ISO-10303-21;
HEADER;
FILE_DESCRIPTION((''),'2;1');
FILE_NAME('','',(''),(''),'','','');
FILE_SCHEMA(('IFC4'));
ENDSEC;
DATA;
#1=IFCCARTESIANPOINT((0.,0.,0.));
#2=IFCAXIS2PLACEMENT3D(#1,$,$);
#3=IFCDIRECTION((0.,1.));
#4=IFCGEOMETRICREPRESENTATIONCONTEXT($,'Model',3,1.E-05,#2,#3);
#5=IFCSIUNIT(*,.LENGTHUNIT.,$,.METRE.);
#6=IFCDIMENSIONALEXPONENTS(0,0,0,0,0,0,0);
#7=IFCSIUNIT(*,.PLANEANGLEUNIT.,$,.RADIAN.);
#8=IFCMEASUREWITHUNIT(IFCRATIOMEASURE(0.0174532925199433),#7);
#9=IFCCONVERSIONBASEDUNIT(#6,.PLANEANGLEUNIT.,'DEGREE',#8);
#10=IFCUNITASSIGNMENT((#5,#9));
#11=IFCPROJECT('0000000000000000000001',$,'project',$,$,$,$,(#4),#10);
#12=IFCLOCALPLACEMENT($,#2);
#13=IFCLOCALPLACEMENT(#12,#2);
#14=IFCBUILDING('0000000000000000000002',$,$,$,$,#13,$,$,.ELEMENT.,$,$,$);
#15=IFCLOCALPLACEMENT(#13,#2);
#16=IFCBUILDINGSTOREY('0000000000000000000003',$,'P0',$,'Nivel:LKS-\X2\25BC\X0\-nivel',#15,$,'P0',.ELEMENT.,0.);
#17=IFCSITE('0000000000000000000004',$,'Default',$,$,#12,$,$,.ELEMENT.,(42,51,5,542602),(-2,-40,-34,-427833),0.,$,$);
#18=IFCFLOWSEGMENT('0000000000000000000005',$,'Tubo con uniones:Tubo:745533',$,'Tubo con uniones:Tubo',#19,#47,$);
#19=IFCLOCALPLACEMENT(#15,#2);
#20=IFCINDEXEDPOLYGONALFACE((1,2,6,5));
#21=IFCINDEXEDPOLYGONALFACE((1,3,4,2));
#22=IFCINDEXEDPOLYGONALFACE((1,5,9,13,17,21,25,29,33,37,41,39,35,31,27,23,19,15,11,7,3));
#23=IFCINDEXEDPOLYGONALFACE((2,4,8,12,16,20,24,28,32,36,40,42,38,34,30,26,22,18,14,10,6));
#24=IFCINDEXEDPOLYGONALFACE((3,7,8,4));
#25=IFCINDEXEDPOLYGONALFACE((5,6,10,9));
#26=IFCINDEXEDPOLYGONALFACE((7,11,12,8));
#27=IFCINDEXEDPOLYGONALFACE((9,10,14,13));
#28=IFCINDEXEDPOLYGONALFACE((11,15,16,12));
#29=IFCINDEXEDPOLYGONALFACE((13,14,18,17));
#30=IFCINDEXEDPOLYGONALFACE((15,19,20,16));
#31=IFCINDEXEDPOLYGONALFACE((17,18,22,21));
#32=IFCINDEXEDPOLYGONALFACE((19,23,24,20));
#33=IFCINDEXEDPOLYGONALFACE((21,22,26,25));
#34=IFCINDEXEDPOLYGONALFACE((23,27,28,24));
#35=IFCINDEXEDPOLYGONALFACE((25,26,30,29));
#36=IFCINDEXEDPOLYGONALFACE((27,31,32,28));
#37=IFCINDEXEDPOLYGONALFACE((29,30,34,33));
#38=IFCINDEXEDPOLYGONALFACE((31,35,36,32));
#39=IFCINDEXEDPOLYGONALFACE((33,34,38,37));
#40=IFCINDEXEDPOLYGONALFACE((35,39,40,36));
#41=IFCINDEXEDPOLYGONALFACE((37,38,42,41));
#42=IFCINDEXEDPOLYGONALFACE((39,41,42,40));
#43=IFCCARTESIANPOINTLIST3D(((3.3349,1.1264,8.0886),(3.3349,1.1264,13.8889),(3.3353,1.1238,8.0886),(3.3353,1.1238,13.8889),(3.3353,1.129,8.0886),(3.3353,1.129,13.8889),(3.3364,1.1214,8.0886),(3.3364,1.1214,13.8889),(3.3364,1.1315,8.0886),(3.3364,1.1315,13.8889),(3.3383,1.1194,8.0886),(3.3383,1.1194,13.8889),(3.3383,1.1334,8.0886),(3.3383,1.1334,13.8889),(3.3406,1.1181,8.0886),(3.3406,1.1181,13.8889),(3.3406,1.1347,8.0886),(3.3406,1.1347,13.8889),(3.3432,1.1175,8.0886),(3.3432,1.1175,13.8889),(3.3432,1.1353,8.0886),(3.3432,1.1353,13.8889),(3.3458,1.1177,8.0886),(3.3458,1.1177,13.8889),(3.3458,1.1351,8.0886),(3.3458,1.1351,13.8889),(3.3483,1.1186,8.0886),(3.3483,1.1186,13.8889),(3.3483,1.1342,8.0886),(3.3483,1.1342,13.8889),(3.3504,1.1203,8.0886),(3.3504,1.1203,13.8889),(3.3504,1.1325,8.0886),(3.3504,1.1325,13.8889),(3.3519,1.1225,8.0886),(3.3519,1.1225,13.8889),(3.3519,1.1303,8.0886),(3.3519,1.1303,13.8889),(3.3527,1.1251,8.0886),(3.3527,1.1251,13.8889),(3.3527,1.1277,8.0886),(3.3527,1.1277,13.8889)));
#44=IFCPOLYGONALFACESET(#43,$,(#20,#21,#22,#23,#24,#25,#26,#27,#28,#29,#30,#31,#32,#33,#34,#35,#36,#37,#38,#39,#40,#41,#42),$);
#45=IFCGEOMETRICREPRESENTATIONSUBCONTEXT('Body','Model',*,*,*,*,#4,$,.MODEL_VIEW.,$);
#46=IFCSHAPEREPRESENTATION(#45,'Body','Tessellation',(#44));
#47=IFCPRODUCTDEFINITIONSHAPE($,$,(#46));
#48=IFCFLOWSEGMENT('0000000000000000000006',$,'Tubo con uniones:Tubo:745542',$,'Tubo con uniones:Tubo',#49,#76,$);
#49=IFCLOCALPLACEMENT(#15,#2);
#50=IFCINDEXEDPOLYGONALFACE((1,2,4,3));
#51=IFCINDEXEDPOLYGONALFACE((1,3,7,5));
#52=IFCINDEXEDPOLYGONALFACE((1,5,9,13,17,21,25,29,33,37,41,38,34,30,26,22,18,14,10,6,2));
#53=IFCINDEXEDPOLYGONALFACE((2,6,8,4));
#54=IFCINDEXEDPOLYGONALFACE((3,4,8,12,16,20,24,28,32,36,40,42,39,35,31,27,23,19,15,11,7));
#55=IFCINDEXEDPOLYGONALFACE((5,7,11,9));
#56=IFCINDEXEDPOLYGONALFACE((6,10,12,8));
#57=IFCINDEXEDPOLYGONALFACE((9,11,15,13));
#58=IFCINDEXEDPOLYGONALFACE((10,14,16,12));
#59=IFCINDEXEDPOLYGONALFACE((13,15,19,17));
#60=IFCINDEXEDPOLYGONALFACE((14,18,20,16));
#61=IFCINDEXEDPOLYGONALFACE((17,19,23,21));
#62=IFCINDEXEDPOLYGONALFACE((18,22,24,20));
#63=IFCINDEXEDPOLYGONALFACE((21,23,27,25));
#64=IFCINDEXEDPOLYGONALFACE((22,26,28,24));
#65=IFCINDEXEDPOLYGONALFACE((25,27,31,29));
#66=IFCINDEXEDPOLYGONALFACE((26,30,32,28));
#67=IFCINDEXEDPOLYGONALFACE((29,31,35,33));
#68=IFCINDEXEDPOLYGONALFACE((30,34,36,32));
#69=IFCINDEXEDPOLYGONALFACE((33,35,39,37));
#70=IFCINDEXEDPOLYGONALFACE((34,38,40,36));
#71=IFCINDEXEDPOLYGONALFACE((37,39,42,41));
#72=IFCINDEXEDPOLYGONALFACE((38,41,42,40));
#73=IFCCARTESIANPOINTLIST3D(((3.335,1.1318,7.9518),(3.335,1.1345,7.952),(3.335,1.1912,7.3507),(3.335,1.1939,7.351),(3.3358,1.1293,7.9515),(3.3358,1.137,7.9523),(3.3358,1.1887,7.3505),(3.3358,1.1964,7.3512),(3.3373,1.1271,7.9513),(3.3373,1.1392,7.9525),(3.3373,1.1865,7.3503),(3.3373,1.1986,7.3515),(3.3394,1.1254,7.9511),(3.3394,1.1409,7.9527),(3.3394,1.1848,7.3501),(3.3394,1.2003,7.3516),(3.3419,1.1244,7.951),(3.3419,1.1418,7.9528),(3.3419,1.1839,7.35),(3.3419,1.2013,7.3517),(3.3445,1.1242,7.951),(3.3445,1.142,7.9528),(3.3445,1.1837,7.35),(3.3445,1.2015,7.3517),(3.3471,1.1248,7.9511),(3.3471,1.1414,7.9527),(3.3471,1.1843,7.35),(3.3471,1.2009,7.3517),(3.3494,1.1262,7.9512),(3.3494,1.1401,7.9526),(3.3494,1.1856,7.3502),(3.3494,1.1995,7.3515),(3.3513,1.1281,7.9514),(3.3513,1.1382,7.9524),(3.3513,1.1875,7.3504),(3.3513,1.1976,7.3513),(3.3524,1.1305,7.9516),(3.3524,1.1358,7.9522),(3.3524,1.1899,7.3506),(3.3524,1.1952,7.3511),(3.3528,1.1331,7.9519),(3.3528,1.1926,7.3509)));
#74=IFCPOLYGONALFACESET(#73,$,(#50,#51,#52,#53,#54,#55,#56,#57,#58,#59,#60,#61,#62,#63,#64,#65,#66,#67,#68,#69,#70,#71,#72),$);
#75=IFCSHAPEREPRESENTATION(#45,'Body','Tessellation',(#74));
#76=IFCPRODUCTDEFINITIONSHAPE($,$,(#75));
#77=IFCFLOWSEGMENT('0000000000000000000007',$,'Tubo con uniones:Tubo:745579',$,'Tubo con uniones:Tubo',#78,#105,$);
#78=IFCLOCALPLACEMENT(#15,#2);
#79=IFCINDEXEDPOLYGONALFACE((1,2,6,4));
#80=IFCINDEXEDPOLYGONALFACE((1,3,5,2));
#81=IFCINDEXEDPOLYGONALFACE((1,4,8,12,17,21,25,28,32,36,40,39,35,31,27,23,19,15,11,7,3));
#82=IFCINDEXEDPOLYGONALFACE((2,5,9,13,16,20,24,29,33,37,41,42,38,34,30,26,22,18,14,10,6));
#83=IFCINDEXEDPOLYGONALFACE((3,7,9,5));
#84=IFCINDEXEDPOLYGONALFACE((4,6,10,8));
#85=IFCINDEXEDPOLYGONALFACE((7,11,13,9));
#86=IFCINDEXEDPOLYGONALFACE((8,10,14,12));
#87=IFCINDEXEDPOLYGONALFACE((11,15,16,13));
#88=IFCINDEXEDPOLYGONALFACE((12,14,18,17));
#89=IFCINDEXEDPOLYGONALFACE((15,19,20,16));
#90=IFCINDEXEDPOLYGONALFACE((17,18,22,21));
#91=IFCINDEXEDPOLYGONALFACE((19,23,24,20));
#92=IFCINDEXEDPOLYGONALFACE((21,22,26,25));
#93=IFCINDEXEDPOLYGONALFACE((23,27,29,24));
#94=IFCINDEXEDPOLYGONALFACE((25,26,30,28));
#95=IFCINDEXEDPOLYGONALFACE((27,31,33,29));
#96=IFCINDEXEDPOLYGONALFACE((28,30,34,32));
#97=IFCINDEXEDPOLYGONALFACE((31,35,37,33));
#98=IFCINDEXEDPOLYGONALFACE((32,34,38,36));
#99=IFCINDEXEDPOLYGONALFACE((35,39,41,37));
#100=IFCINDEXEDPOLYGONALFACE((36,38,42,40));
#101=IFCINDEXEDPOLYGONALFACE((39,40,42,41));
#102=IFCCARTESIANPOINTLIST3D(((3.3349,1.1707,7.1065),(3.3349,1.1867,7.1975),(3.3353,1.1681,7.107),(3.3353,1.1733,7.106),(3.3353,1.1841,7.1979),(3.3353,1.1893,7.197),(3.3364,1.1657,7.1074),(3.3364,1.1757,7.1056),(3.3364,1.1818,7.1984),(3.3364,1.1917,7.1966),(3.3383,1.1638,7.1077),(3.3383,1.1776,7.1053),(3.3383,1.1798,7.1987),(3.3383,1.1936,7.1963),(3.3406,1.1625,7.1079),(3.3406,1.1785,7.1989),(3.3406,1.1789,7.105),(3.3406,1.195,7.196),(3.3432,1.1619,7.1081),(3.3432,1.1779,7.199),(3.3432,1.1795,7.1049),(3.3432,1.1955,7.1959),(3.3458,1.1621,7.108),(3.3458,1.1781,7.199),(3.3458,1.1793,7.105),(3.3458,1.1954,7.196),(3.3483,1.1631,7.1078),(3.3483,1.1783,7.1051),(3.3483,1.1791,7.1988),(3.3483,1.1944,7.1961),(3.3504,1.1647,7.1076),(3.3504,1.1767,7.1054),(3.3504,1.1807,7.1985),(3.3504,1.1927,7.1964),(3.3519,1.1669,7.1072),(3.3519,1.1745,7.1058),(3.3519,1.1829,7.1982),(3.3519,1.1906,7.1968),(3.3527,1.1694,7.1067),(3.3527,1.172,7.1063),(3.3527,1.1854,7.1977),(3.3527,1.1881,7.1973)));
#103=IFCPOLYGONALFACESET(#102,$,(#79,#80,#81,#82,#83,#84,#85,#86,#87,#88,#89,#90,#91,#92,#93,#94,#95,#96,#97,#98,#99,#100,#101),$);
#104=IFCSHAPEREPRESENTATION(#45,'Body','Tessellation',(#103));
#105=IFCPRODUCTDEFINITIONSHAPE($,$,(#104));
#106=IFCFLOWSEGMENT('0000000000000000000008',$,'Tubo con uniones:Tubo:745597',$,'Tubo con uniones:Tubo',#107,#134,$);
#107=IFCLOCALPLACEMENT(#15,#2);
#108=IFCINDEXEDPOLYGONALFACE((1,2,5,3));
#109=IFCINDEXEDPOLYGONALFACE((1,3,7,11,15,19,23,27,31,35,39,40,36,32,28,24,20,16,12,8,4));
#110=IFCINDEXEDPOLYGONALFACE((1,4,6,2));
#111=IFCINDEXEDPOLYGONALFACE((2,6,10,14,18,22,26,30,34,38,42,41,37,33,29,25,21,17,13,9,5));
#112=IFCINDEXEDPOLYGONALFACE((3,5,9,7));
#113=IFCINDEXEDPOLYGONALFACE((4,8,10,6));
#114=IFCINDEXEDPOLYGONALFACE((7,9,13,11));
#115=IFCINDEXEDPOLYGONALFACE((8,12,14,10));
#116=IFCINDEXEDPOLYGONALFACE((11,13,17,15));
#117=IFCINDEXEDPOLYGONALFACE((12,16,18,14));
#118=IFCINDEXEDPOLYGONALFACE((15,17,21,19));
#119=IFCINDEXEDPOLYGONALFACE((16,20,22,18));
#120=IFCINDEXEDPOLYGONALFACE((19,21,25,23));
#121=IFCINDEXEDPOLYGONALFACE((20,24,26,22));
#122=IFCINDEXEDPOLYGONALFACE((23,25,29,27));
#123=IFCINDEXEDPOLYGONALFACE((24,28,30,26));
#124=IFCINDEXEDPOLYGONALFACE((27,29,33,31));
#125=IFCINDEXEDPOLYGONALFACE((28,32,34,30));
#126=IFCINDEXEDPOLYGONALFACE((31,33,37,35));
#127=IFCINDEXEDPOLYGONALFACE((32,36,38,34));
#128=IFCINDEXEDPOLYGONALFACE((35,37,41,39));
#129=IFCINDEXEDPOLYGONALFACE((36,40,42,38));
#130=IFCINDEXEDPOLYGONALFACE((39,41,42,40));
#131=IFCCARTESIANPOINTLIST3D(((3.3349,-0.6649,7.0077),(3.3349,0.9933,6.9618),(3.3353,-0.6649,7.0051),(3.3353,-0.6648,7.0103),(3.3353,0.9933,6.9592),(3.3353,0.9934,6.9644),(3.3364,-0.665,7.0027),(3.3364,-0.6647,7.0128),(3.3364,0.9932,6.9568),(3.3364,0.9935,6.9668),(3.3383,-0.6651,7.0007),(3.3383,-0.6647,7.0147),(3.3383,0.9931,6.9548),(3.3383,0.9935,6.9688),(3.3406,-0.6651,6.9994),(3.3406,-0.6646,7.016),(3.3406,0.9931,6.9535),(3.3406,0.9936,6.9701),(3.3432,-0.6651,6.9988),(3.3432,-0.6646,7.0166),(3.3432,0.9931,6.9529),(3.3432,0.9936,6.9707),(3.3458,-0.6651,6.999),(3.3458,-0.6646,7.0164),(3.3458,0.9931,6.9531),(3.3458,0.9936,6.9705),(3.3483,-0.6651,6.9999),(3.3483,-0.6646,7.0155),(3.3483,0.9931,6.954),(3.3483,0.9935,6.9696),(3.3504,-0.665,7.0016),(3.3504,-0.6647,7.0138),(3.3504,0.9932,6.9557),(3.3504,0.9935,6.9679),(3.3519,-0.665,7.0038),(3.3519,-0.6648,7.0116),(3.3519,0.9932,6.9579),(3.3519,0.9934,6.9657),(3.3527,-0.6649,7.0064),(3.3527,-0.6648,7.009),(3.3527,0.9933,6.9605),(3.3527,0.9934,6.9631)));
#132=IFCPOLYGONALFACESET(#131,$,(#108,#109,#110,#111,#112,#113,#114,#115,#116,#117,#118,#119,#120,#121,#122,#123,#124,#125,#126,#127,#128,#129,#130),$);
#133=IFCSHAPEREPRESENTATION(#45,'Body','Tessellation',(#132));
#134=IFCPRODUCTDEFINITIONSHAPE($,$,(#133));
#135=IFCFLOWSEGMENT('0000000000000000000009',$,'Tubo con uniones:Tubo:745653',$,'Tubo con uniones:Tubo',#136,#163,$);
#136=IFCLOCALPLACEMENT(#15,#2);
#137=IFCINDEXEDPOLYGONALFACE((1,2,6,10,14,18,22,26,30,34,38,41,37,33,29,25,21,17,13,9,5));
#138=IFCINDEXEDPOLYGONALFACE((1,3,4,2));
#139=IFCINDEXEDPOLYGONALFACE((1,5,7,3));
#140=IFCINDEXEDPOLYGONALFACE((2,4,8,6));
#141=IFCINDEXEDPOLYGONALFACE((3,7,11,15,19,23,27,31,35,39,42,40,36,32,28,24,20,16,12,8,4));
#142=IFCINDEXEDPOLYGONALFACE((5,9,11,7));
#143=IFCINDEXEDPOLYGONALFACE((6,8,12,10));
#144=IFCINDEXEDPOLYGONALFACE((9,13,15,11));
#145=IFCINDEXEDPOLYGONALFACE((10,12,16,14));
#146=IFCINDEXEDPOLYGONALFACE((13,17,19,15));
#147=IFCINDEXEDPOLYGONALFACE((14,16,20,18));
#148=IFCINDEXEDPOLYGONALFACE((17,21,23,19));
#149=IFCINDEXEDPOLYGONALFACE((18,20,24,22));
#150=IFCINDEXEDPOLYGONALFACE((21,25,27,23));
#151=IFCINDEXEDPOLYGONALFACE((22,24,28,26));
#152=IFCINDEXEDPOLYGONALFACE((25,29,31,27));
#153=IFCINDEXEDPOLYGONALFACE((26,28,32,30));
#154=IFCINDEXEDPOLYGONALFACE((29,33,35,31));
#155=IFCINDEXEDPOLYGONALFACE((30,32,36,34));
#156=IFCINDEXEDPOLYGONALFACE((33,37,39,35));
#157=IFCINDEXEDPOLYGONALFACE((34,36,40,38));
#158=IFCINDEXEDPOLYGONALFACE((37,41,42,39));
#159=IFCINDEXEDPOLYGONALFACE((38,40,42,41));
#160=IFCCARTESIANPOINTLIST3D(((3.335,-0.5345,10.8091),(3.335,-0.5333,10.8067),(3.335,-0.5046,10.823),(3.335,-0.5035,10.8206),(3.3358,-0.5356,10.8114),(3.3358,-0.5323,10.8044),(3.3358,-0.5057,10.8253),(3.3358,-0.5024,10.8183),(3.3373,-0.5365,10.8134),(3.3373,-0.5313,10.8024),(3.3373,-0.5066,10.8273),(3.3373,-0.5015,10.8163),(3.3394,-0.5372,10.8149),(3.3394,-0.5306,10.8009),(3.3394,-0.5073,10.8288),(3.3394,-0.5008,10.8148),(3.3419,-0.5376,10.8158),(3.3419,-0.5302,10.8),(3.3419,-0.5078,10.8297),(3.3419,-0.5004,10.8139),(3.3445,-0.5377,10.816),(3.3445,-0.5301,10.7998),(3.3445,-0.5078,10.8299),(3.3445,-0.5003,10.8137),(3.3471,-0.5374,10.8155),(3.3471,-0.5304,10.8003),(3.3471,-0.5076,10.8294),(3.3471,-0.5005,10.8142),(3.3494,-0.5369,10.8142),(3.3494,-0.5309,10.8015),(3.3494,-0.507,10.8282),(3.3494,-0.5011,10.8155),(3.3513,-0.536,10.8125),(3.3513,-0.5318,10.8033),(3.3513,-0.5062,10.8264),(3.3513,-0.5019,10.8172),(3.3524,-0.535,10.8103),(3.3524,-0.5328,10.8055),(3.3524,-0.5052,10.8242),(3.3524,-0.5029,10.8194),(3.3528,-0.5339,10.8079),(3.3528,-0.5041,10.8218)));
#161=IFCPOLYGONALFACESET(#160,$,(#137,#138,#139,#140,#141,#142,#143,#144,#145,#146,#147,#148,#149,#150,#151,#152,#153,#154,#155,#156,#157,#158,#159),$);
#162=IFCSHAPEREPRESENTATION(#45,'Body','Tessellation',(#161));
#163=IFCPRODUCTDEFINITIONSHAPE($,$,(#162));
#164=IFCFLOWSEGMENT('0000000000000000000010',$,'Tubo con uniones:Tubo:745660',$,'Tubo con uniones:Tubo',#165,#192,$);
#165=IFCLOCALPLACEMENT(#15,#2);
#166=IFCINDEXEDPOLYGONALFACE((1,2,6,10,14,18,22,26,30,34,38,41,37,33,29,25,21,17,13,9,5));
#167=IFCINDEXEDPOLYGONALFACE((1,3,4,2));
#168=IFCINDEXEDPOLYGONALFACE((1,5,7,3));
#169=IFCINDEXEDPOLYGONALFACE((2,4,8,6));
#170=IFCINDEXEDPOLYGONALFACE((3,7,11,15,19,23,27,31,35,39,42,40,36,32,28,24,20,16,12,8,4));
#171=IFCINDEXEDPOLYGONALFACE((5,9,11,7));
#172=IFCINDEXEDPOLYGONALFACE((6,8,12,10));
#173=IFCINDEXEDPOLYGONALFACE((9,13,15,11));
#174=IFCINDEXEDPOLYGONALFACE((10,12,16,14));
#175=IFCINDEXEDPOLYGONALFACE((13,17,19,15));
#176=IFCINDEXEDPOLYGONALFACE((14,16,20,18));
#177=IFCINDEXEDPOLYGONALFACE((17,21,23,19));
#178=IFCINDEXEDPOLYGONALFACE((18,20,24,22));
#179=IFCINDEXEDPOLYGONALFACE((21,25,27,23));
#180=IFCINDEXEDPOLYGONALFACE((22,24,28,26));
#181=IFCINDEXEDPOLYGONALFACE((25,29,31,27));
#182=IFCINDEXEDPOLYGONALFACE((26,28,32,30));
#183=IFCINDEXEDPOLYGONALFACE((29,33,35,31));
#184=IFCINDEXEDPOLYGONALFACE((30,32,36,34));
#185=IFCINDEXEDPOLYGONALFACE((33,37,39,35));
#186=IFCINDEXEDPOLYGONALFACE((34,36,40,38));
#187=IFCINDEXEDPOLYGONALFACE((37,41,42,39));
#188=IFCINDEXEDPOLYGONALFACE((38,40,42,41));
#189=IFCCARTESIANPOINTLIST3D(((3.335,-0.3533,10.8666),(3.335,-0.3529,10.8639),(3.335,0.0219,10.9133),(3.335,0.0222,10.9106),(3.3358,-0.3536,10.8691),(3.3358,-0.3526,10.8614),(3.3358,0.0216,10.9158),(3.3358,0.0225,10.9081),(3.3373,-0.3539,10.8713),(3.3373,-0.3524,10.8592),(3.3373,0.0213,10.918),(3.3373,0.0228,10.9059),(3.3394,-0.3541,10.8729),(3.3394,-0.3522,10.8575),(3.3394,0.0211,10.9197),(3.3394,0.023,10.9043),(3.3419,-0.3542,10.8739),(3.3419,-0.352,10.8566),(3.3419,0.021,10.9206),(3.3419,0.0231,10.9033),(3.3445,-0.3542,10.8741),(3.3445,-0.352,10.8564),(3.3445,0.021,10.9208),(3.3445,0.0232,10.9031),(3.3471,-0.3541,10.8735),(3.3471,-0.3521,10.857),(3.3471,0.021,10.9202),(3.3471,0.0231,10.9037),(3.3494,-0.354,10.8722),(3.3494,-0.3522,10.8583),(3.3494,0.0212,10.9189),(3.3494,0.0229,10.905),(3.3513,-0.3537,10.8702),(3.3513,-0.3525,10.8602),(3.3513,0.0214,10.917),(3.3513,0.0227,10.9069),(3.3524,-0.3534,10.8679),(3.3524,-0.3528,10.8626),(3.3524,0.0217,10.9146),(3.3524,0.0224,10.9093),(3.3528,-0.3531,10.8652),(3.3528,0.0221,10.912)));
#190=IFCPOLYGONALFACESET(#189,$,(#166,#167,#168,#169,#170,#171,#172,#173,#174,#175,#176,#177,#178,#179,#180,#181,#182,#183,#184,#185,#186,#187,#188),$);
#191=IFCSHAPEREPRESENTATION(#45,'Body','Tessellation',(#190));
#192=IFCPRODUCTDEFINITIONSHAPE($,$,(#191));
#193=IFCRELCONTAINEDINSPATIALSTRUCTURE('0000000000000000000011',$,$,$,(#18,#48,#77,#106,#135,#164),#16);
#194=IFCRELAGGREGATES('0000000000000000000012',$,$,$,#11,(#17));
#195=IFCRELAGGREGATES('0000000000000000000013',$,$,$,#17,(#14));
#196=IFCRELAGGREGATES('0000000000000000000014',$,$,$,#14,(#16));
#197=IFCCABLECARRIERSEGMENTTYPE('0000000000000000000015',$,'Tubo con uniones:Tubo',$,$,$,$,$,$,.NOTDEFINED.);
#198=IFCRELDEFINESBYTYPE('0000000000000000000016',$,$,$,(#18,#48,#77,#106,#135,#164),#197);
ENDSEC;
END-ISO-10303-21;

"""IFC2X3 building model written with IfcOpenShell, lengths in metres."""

from ifc_helpers import new_model, entity, si_unit, converted_unit, direction, frame, frame_2d, origin, origin_2d_with_axis, place, context, subcontext, project, spatial, circle, extrude, type_object, element, save


model = new_model("IFC2X3")

# Units and contexts
model_context = context("Model", 3, precision=1e-05, world=origin(), true_north=direction((0.0, 1.0)))
body_context = subcontext(model_context, "Body", "Model", "MODEL_VIEW")
ifc_project = project(units=[si_unit("LENGTHUNIT", "METRE"), converted_unit("PLANEANGLEUNIT", "DEGREE", entity("IfcRatioMeasure", 0.0174532925199433), si_unit("PLANEANGLEUNIT", "RADIAN"), dimensions=[0, 0, 0, 0, 0, 0, 0])], contexts=[model_context])

# Site, building, storey
site_placement = place(None, origin())
site = spatial("IfcSite", under=ifc_project, at=site_placement, Name="Default", CompositionType="ELEMENT", RefLatitude=(42, 51, 5, 542602), RefLongitude=(-2, -40, -34, -427833), RefElevation=0.0)
building_placement = place(site_placement, origin())
building = spatial("IfcBuilding", under=site, at=building_placement, CompositionType="ELEMENT")
storey_placement = place(building_placement, origin())
storey = spatial("IfcBuildingStorey", under=building, at=storey_placement, Name="P0", ObjectType="Nivel:LKS-▼-nivel", LongName="P0", CompositionType="ELEMENT", Elevation=0.0)

# Flow segments
cable_carrier_segment_type = type_object("IfcCableCarrierSegmentType", Name="Tubo con uniones:Tubo", PredefinedType="NOTDEFINED")
flow_segment_1_placement = place(storey_placement, origin())
element("IfcFlowSegment", 1, at=flow_segment_1_placement, inside=storey, type_object=cable_carrier_segment_type, Name="Tubo con uniones:Tubo:745533", ObjectType="Tubo con uniones:Tubo", context=body_context, shape_type="SweptSolid", body=[
    extrude(circle(Radius=0.009, at=origin_2d_with_axis()), frame((3.3439, 1.1264, 8.0886), z_axis=(0.0, 0.0, 1.0), x_axis=(-1.0, 0.0, 0.0)), (0.0, 0.0, 1.0), 5.8003),
])
flow_segment_2_placement = place(storey_placement, origin())
element("IfcFlowSegment", 2, at=flow_segment_2_placement, inside=storey, type_object=cable_carrier_segment_type, Name="Tubo con uniones:Tubo:745542", ObjectType="Tubo con uniones:Tubo", context=body_context, shape_type="SweptSolid", body=[
    extrude(circle(Radius=0.009, at=origin_2d_with_axis()), frame((3.3439, 1.1331, 7.9519), z_axis=(0.0, 0.098397, -0.995147), x_axis=(1.0, 0.0, 0.0)), (0.0, 0.0, 1.0), 0.604),
])
flow_segment_3_placement = place(storey_placement, origin())
element("IfcFlowSegment", 3, at=flow_segment_3_placement, inside=storey, type_object=cable_carrier_segment_type, Name="Tubo con uniones:Tubo:745579", ObjectType="Tubo con uniones:Tubo", context=body_context, shape_type="SweptSolid", body=[
    extrude(circle(Radius=0.009, at=origin_2d_with_axis()), frame((3.3439, 1.1707, 7.1065), z_axis=(0.0, 0.173648, 0.984808), x_axis=(-1.0, 0.0, 0.0)), (0.0, 0.0, 1.0), 0.0924),
])
flow_segment_4_placement = place(storey_placement, origin())
element("IfcFlowSegment", 4, at=flow_segment_4_placement, inside=storey, type_object=cable_carrier_segment_type, Name="Tubo con uniones:Tubo:745597", ObjectType="Tubo con uniones:Tubo", context=body_context, shape_type="SweptSolid", body=[
    extrude(circle(Radius=0.009, at=frame_2d((0.0, 0.0), x_axis=(1.0, 0.0))), frame((3.3439, 0.9933, 6.9618), z_axis=(0.0, -0.999617, 0.027672), x_axis=(-1.0, 0.0, 0.0)), (0.0, 0.0, 1.0), 1.6588),
])
flow_segment_5_placement = place(storey_placement, origin())
element("IfcFlowSegment", 5, at=flow_segment_5_placement, inside=storey, type_object=cable_carrier_segment_type, Name="Tubo con uniones:Tubo:745653", ObjectType="Tubo con uniones:Tubo", context=body_context, shape_type="SweptSolid", body=[
    extrude(circle(Radius=0.009, at=frame_2d((0.0, 0.0), x_axis=(1.0, 0.0))), frame((3.3439, -0.5339, 10.8079), z_axis=(0.0, 0.906308, 0.422618), x_axis=(1.0, 0.0, 0.0)), (0.0, 0.0, 1.0), 0.0329),
])
flow_segment_6_placement = place(storey_placement, origin())
element("IfcFlowSegment", 6, at=flow_segment_6_placement, inside=storey, type_object=cable_carrier_segment_type, Name="Tubo con uniones:Tubo:745660", ObjectType="Tubo con uniones:Tubo", context=body_context, shape_type="SweptSolid", body=[
    extrude(circle(Radius=0.009, at=frame_2d((0.0, 0.0), x_axis=(1.0, 0.0))), frame((3.3439, -0.3531, 10.8652), z_axis=(0.0, 0.992335, 0.123577), x_axis=(1.0, 0.0, 0.0)), (0.0, 0.0, 1.0), 0.3781),
])

save(model, "model.ifc")
